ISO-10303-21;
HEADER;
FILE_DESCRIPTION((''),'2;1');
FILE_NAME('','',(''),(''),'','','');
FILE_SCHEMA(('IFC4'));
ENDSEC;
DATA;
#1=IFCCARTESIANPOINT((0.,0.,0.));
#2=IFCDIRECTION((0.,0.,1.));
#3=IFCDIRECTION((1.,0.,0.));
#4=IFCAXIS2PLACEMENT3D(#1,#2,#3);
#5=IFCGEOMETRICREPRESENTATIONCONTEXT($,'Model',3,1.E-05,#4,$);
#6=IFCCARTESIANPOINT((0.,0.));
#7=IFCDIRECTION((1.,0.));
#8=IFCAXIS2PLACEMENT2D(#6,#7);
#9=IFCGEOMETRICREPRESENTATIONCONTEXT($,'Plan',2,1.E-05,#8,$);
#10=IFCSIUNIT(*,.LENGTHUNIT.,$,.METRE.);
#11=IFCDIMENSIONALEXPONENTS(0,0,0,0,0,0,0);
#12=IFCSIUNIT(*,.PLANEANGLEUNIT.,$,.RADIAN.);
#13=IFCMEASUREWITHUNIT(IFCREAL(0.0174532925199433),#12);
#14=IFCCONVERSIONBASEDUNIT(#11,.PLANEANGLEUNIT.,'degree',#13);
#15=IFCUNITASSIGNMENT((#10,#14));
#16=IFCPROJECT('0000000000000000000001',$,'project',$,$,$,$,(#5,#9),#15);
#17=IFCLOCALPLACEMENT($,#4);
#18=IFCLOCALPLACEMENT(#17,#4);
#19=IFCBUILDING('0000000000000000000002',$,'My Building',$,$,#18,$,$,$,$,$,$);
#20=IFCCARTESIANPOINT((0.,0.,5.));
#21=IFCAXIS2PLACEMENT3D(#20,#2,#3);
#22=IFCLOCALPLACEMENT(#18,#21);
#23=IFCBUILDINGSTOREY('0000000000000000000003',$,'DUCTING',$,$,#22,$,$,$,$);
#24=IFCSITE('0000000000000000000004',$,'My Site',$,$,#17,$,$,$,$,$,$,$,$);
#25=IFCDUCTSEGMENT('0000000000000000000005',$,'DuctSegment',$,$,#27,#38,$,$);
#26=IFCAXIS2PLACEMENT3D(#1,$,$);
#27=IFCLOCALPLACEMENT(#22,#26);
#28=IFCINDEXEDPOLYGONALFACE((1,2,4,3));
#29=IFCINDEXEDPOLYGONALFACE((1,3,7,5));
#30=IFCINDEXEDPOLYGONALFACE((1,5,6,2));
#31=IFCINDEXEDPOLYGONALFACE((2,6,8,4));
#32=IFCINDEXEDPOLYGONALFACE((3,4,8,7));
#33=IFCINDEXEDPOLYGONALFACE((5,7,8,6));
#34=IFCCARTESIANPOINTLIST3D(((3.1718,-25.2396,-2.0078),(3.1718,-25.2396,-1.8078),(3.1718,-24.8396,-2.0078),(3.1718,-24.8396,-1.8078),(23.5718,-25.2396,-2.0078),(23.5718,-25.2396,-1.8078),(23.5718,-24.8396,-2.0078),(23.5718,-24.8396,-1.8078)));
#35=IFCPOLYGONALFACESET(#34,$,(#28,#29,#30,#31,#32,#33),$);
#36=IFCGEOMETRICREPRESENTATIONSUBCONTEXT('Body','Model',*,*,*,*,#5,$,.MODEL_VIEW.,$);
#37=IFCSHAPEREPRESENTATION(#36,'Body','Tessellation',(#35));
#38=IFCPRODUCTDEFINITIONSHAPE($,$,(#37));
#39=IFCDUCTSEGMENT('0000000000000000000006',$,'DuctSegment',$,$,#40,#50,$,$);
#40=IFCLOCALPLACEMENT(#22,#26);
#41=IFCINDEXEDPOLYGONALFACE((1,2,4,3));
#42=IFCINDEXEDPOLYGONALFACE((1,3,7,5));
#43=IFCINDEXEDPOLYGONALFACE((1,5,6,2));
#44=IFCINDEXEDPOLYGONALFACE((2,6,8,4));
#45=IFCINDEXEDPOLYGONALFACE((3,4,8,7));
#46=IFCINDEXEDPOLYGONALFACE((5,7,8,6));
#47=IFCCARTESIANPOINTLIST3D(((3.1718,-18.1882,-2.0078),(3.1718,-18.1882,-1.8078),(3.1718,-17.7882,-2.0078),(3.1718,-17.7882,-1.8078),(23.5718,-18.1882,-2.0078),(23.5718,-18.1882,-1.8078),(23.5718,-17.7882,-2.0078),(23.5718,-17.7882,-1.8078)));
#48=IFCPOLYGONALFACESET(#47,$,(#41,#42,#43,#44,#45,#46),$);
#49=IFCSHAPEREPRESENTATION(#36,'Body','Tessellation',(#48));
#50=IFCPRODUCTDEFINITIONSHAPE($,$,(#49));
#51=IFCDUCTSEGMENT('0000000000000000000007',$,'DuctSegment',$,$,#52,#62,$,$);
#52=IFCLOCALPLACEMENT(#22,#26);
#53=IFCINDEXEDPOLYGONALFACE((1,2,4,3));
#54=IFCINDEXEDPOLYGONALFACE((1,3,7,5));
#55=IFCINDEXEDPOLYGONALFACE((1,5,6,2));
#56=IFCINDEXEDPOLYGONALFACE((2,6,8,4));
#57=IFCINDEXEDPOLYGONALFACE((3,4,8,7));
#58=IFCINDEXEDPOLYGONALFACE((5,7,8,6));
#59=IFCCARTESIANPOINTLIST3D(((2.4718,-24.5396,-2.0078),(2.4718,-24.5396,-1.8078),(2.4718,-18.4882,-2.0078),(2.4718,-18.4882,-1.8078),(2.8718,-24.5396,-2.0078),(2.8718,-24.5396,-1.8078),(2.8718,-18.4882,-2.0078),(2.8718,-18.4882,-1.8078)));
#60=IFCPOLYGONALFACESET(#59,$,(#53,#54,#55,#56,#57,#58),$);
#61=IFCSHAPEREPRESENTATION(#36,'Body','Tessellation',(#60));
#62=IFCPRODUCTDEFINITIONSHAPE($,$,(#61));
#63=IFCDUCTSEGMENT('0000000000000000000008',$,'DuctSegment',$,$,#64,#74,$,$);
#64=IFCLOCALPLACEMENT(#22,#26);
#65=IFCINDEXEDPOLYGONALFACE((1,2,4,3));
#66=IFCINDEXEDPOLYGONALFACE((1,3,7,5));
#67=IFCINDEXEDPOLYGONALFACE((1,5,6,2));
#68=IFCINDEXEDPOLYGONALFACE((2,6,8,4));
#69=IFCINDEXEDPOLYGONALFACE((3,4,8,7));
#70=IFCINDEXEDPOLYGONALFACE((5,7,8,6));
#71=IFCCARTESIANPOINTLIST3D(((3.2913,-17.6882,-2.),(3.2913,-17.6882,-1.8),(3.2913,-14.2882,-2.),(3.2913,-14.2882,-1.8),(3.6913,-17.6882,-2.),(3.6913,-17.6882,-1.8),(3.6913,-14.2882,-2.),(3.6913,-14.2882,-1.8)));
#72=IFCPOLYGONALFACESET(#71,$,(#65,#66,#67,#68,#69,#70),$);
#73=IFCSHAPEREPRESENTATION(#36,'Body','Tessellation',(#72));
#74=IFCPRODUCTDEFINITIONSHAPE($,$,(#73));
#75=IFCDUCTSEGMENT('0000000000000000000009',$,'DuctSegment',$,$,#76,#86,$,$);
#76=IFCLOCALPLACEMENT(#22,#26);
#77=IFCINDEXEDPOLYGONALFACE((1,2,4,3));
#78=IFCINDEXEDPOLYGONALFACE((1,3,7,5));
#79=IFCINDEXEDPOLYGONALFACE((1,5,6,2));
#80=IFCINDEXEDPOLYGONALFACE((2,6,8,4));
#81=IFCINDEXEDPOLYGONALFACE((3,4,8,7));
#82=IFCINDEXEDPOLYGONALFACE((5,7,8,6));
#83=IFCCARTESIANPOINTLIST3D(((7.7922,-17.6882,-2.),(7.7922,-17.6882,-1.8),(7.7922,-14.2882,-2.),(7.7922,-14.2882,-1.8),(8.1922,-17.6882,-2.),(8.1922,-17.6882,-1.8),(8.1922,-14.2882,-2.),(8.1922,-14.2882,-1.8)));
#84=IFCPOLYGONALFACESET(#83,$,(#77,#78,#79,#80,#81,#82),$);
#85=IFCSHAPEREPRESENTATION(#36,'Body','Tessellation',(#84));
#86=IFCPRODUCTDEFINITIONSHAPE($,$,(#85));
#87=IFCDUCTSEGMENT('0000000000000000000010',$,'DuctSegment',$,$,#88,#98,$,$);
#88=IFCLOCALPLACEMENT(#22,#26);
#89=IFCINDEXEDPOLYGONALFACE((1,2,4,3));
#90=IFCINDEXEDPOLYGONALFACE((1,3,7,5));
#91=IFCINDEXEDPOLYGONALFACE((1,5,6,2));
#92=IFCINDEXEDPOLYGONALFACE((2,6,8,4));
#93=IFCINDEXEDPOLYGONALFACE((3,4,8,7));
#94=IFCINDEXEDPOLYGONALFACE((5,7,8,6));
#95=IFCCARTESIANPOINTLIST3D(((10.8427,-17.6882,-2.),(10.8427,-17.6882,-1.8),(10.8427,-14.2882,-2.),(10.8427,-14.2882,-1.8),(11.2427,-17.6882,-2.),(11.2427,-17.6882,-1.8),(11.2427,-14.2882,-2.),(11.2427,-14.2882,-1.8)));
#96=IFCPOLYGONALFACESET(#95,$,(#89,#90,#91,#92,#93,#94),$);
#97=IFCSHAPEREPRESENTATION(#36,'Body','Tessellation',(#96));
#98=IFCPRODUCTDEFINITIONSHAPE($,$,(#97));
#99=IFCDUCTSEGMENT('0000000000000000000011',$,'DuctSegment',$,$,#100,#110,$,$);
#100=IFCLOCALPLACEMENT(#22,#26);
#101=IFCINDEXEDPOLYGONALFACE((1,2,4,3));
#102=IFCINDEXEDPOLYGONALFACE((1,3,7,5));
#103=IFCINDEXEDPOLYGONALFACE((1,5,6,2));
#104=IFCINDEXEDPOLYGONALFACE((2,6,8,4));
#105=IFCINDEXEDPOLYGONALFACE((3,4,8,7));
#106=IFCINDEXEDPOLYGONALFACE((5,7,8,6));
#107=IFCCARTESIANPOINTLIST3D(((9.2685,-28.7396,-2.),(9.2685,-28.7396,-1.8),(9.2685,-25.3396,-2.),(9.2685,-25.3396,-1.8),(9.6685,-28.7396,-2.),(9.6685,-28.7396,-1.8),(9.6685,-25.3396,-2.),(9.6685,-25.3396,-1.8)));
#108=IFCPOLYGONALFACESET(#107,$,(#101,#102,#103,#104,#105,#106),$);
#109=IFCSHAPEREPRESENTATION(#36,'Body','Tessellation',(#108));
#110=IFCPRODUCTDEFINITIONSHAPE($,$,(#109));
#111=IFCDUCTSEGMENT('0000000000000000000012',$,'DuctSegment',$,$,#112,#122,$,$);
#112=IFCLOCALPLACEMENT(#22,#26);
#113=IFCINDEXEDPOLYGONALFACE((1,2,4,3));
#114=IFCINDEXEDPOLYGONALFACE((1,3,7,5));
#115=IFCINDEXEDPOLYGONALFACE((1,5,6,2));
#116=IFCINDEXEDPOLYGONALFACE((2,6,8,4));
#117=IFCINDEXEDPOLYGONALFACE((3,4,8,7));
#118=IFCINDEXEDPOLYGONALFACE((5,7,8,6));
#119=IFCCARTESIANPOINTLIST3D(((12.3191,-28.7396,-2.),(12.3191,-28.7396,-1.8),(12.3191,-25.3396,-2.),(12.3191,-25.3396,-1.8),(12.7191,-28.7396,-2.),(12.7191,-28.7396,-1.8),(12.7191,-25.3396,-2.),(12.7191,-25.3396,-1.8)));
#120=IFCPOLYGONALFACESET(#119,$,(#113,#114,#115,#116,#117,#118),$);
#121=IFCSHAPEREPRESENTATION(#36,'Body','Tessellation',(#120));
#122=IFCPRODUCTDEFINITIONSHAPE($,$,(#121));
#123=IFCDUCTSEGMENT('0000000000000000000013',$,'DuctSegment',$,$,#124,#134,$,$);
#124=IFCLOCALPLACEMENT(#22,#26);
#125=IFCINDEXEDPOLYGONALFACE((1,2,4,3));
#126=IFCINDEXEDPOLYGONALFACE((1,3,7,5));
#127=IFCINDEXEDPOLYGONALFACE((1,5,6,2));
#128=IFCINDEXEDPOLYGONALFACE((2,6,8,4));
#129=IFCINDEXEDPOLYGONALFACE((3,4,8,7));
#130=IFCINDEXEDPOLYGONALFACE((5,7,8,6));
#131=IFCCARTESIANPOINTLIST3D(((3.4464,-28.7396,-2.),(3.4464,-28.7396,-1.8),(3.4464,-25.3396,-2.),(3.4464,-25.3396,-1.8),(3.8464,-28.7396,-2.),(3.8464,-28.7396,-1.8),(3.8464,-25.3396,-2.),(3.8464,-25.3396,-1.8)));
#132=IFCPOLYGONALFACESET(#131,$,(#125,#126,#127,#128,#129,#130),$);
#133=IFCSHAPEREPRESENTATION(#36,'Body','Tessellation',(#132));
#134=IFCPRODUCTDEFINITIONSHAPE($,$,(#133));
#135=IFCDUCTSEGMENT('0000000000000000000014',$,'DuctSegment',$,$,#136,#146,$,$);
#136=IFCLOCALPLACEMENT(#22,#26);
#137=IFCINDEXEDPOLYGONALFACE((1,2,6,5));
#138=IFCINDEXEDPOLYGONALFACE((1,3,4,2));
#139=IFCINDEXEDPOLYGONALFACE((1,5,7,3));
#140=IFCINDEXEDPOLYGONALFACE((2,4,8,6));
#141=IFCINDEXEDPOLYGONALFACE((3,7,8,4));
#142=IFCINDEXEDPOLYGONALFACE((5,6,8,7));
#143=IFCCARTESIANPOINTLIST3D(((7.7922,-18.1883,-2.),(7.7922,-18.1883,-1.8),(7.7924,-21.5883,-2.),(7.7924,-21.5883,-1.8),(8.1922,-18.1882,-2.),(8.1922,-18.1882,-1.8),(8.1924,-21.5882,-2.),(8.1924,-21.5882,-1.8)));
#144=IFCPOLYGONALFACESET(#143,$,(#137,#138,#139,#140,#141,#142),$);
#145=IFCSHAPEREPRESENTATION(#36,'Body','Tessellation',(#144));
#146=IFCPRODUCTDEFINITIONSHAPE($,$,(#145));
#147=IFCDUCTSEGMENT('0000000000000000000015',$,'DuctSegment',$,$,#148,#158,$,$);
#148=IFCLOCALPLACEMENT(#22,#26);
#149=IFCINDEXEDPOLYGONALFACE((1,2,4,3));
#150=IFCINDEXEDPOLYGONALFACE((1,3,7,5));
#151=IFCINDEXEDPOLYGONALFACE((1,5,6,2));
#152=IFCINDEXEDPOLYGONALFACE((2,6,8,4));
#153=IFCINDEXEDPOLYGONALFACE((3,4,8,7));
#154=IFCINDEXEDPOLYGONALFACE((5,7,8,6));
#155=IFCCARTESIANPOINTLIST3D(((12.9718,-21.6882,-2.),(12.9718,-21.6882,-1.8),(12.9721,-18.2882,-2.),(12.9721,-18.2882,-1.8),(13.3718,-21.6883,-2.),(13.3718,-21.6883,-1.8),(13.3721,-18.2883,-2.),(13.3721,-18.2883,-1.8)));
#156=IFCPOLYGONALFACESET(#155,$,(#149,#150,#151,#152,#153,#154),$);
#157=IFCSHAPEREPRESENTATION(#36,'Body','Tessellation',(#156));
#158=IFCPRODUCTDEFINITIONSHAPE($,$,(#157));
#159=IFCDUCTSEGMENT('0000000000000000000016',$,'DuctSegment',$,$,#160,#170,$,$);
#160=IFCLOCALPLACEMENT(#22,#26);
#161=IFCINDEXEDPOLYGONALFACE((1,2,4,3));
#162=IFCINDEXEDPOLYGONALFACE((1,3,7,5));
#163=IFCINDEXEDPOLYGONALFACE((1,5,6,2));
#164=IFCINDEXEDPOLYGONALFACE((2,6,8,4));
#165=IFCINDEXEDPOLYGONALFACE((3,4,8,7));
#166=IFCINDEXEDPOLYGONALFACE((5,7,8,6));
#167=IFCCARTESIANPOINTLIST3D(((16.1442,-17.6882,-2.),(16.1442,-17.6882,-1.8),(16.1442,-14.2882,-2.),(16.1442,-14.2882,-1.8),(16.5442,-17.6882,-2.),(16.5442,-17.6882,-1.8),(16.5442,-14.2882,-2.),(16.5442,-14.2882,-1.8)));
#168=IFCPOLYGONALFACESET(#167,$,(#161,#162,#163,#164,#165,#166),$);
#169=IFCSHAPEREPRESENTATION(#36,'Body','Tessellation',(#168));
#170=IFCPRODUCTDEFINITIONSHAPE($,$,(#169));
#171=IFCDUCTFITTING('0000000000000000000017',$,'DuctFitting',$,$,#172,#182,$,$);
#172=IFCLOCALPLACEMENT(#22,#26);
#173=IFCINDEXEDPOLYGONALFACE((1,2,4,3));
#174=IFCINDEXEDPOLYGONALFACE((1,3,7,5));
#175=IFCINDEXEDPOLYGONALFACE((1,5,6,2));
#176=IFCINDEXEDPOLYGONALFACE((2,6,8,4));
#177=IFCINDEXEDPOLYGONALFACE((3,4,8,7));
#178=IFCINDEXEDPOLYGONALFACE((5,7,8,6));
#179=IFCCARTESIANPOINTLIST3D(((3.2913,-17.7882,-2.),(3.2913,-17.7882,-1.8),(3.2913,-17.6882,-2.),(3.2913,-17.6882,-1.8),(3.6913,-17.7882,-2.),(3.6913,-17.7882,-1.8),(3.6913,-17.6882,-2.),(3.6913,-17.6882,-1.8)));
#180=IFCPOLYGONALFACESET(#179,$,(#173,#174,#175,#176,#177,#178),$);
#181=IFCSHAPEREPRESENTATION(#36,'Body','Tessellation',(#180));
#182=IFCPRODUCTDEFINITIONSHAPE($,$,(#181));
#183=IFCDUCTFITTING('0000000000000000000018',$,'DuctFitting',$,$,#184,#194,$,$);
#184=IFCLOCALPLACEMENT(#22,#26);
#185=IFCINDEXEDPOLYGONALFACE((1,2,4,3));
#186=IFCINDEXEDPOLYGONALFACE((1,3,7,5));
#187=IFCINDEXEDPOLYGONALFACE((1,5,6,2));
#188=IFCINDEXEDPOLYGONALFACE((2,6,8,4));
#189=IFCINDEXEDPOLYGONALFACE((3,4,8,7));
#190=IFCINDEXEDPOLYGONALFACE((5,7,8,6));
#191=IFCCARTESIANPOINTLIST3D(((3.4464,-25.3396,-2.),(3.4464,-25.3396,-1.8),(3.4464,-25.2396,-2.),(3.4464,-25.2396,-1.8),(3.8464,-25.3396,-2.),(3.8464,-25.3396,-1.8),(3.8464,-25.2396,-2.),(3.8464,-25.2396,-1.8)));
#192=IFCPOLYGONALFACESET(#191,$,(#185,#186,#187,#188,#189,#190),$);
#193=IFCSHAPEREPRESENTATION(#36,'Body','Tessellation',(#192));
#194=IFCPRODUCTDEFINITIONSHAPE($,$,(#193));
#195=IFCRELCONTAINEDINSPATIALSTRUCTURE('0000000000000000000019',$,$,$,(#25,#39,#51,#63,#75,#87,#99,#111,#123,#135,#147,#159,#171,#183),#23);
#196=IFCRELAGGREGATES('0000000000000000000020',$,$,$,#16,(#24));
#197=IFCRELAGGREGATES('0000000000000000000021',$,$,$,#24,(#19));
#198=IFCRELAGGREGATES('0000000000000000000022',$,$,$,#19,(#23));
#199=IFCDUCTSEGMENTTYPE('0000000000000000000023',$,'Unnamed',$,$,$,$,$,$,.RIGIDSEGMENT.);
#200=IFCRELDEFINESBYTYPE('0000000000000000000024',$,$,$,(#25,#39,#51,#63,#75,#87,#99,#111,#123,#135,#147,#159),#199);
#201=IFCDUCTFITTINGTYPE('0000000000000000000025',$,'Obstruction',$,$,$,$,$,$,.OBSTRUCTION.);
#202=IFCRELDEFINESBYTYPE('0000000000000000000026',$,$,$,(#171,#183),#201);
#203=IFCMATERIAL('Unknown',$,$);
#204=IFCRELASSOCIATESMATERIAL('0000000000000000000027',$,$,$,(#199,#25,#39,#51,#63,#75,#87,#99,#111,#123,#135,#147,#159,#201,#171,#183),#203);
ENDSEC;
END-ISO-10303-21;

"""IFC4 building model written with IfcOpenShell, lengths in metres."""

from ifc_helpers import new_model, entity, si_unit, converted_unit, frame, origin_with_axes, origin_2d_with_axis, place, context, subcontext, project, spatial, rectangle, extrude, material, material_profile, profile_set, profile_usage, type_object, element, save


model = new_model("IFC4")

# Units and contexts
model_context = context("Model", 3, precision=1e-05, world=origin_with_axes())
plan_context = context("Plan", 2, precision=1e-05, world=origin_2d_with_axis())
body_context = subcontext(model_context, "Body", "Model", "MODEL_VIEW")
ifc_project = project(units=[si_unit("LENGTHUNIT", "METRE"), converted_unit("PLANEANGLEUNIT", "degree", entity("IfcReal", 0.0174532925199433), si_unit("PLANEANGLEUNIT", "RADIAN"), dimensions=[0, 0, 0, 0, 0, 0, 0])], contexts=[model_context, plan_context])

# Site, building, storey
site_placement = place(None, origin_with_axes())
site = spatial("IfcSite", under=ifc_project, at=site_placement, Name="My Site")
building_placement = place(site_placement, origin_with_axes())
building = spatial("IfcBuilding", under=site, at=building_placement, Name="My Building")
storey_placement = place(building_placement, frame((0.0, 0.0, 5.0), z_axis=(0.0, 0.0, 1.0), x_axis=(1.0, 0.0, 0.0)))
storey = spatial("IfcBuildingStorey", under=building, at=storey_placement, Name="DUCTING")

# Duct segments
ifc_material = material(Name="Unknown")
ifc_material_profile_1 = material_profile(ifc_material, rectangle(XDim=0.4, YDim=0.2))
ifc_profile_set_1 = profile_set([ifc_material_profile_1])
ifc_profile_usage_1 = profile_usage(ifc_profile_set_1, cardinal=5)
duct_segment_type = type_object("IfcDuctSegmentType", Name="Unnamed", PredefinedType="RIGIDSEGMENT", material=ifc_profile_set_1)
duct_segment_1_placement = place(storey_placement, frame((3.1718, -25.0396, -1.9078), z_axis=(1.0, 0.0, 0.0), x_axis=(0.0, 1.0, 0.0)))
element("IfcDuctSegment", 1, at=duct_segment_1_placement, inside=storey, type_object=duct_segment_type, material=ifc_profile_usage_1, Name="DuctSegment", context=body_context, shape_type="SweptSolid", body=[
    extrude(rectangle(XDim=0.4, YDim=0.2), origin_with_axes(), (0.0, 0.0, 1.0), 20.4),
])
ifc_profile_usage_2 = profile_usage(ifc_profile_set_1, cardinal=5)
duct_segment_2_placement = place(storey_placement, frame((3.1718, -17.9882, -1.9078), z_axis=(1.0, 0.0, 0.0), x_axis=(0.0, 1.0, 0.0)))
element("IfcDuctSegment", 2, at=duct_segment_2_placement, inside=storey, type_object=duct_segment_type, material=ifc_profile_usage_2, Name="DuctSegment", context=body_context, shape_type="SweptSolid", body=[
    extrude(rectangle(XDim=0.4, YDim=0.2), origin_with_axes(), (0.0, 0.0, 1.0), 20.4),
])
ifc_profile_usage_3 = profile_usage(ifc_profile_set_1, cardinal=5)
duct_segment_3_placement = place(storey_placement, frame((2.6718, -18.4882, -1.9078), z_axis=(0.0, -1.0, 0.0), x_axis=(1.0, 0.0, 0.0)))
element("IfcDuctSegment", 3, at=duct_segment_3_placement, inside=storey, type_object=duct_segment_type, material=ifc_profile_usage_3, Name="DuctSegment", context=body_context, shape_type="SweptSolid", body=[
    extrude(rectangle(XDim=0.4, YDim=0.2), origin_with_axes(), (0.0, 0.0, 1.0), 6.0513),
])
ifc_profile_usage_4 = profile_usage(ifc_profile_set_1, cardinal=5)
duct_segment_4_placement = place(storey_placement, frame((3.4913, -17.6882, -1.9), z_axis=(0.0, 1.0, 0.0), x_axis=(-1.0, 0.0, 0.0)))
element("IfcDuctSegment", 4, at=duct_segment_4_placement, inside=storey, type_object=duct_segment_type, material=ifc_profile_usage_4, Name="DuctSegment", context=body_context, shape_type="SweptSolid", body=[
    extrude(rectangle(XDim=0.4, YDim=0.2), origin_with_axes(), (0.0, 0.0, 1.0), 3.4),
])
ifc_profile_usage_5 = profile_usage(ifc_profile_set_1, cardinal=5)
duct_segment_5_placement = place(storey_placement, frame((7.9922, -17.6882, -1.9), z_axis=(0.0, 1.0, 0.0), x_axis=(-1.0, 0.0, 0.0)))
element("IfcDuctSegment", 5, at=duct_segment_5_placement, inside=storey, type_object=duct_segment_type, material=ifc_profile_usage_5, Name="DuctSegment", context=body_context, shape_type="SweptSolid", body=[
    extrude(rectangle(XDim=0.4, YDim=0.2), origin_with_axes(), (0.0, 0.0, 1.0), 3.4),
])
ifc_profile_usage_6 = profile_usage(ifc_profile_set_1, cardinal=5)
duct_segment_6_placement = place(storey_placement, frame((11.0427, -17.6882, -1.9), z_axis=(0.0, 1.0, 0.0), x_axis=(-1.0, 0.0, 0.0)))
element("IfcDuctSegment", 6, at=duct_segment_6_placement, inside=storey, type_object=duct_segment_type, material=ifc_profile_usage_6, Name="DuctSegment", context=body_context, shape_type="SweptSolid", body=[
    extrude(rectangle(XDim=0.4, YDim=0.2), origin_with_axes(), (0.0, 0.0, 1.0), 3.4),
])
ifc_profile_usage_7 = profile_usage(ifc_profile_set_1, cardinal=5)
duct_segment_7_placement = place(storey_placement, frame((9.4685, -28.7396, -1.9), z_axis=(0.0, 1.0, 0.0), x_axis=(-1.0, 0.0, 0.0)))
element("IfcDuctSegment", 7, at=duct_segment_7_placement, inside=storey, type_object=duct_segment_type, material=ifc_profile_usage_7, Name="DuctSegment", context=body_context, shape_type="SweptSolid", body=[
    extrude(rectangle(XDim=0.4, YDim=0.2), origin_with_axes(), (0.0, 0.0, 1.0), 3.4),
])
ifc_profile_usage_8 = profile_usage(ifc_profile_set_1, cardinal=5)
duct_segment_8_placement = place(storey_placement, frame((12.5191, -28.7396, -1.9), z_axis=(0.0, 1.0, 0.0), x_axis=(-1.0, 0.0, 0.0)))
element("IfcDuctSegment", 8, at=duct_segment_8_placement, inside=storey, type_object=duct_segment_type, material=ifc_profile_usage_8, Name="DuctSegment", context=body_context, shape_type="SweptSolid", body=[
    extrude(rectangle(XDim=0.4, YDim=0.2), origin_with_axes(), (0.0, 0.0, 1.0), 3.4),
])
ifc_profile_usage_9 = profile_usage(ifc_profile_set_1, cardinal=5)
duct_segment_9_placement = place(storey_placement, frame((3.6464, -25.3396, -1.9), z_axis=(0.0, -1.0, 0.0), x_axis=(-1.0, 0.0, 0.0)))
element("IfcDuctSegment", 9, at=duct_segment_9_placement, inside=storey, type_object=duct_segment_type, material=ifc_profile_usage_9, Name="DuctSegment", context=body_context, shape_type="SweptSolid", body=[
    extrude(rectangle(XDim=0.4, YDim=0.2), origin_with_axes(), (0.0, 0.0, 1.0), 3.4),
])
ifc_profile_usage_10 = profile_usage(ifc_profile_set_1, cardinal=5)
duct_segment_10_placement = place(storey_placement, frame((7.9922, -18.1883, -1.9), z_axis=(0.000078, -1.0, 0.0), x_axis=(1.0, 0.000078, 0.0)))
element("IfcDuctSegment", 10, at=duct_segment_10_placement, inside=storey, type_object=duct_segment_type, material=ifc_profile_usage_10, Name="DuctSegment", context=body_context, shape_type="SweptSolid", body=[
    extrude(rectangle(XDim=0.4, YDim=0.2), origin_with_axes(), (0.0, 0.0, 1.0), 3.4),
])
ifc_profile_usage_11 = profile_usage(ifc_profile_set_1, cardinal=5)
duct_segment_11_placement = place(storey_placement, frame((13.1718, -21.6883, -1.9), z_axis=(0.000078, 1.0, 0.0), x_axis=(1.0, -0.000078, 0.0)))
element("IfcDuctSegment", 11, at=duct_segment_11_placement, inside=storey, type_object=duct_segment_type, material=ifc_profile_usage_11, Name="DuctSegment", context=body_context, shape_type="SweptSolid", body=[
    extrude(rectangle(XDim=0.4, YDim=0.2), origin_with_axes(), (0.0, 0.0, 1.0), 3.4),
])
ifc_profile_usage_12 = profile_usage(ifc_profile_set_1, cardinal=5)
duct_segment_12_placement = place(storey_placement, frame((16.3442, -17.6882, -1.9), z_axis=(0.0, 1.0, 0.0), x_axis=(-1.0, 0.0, 0.0)))
element("IfcDuctSegment", 12, at=duct_segment_12_placement, inside=storey, type_object=duct_segment_type, material=ifc_profile_usage_12, Name="DuctSegment", context=body_context, shape_type="SweptSolid", body=[
    extrude(rectangle(XDim=0.4, YDim=0.2), origin_with_axes(), (0.0, 0.0, 1.0), 3.4),
])

# Duct fittings
ifc_material_profile_2 = material_profile(ifc_material, rectangle(XDim=0.4, YDim=0.2))
ifc_profile_set_2 = profile_set([ifc_material_profile_2])
ifc_profile_usage_13 = profile_usage(ifc_profile_set_2, cardinal=5)
duct_fitting_type = type_object("IfcDuctFittingType", Name="Obstruction", PredefinedType="OBSTRUCTION", material=ifc_profile_set_2)
duct_fitting_1_placement = place(storey_placement, frame((3.4913, -17.7882, -1.9), z_axis=(0.0, 1.0, 0.0), x_axis=(-1.0, 0.0, 0.0)))
element("IfcDuctFitting", 13, at=duct_fitting_1_placement, inside=storey, type_object=duct_fitting_type, material=ifc_profile_usage_13, Name="DuctFitting", context=body_context, shape_type="SweptSolid", body=[
    extrude(rectangle(XDim=0.4, YDim=0.2), origin_with_axes(), (0.0, 0.0, 1.0), 0.1),
])
ifc_profile_usage_14 = profile_usage(ifc_profile_set_2, cardinal=5)
duct_fitting_2_placement = place(storey_placement, frame((3.6464, -25.2396, -1.9), z_axis=(0.0, -1.0, 0.0), x_axis=(-1.0, 0.0, 0.0)))
element("IfcDuctFitting", 14, at=duct_fitting_2_placement, inside=storey, type_object=duct_fitting_type, material=ifc_profile_usage_14, Name="DuctFitting", context=body_context, shape_type="SweptSolid", body=[
    extrude(rectangle(XDim=0.4, YDim=0.2), origin_with_axes(), (0.0, 0.0, 1.0), 0.1),
])

save(model, "model.ifc")
